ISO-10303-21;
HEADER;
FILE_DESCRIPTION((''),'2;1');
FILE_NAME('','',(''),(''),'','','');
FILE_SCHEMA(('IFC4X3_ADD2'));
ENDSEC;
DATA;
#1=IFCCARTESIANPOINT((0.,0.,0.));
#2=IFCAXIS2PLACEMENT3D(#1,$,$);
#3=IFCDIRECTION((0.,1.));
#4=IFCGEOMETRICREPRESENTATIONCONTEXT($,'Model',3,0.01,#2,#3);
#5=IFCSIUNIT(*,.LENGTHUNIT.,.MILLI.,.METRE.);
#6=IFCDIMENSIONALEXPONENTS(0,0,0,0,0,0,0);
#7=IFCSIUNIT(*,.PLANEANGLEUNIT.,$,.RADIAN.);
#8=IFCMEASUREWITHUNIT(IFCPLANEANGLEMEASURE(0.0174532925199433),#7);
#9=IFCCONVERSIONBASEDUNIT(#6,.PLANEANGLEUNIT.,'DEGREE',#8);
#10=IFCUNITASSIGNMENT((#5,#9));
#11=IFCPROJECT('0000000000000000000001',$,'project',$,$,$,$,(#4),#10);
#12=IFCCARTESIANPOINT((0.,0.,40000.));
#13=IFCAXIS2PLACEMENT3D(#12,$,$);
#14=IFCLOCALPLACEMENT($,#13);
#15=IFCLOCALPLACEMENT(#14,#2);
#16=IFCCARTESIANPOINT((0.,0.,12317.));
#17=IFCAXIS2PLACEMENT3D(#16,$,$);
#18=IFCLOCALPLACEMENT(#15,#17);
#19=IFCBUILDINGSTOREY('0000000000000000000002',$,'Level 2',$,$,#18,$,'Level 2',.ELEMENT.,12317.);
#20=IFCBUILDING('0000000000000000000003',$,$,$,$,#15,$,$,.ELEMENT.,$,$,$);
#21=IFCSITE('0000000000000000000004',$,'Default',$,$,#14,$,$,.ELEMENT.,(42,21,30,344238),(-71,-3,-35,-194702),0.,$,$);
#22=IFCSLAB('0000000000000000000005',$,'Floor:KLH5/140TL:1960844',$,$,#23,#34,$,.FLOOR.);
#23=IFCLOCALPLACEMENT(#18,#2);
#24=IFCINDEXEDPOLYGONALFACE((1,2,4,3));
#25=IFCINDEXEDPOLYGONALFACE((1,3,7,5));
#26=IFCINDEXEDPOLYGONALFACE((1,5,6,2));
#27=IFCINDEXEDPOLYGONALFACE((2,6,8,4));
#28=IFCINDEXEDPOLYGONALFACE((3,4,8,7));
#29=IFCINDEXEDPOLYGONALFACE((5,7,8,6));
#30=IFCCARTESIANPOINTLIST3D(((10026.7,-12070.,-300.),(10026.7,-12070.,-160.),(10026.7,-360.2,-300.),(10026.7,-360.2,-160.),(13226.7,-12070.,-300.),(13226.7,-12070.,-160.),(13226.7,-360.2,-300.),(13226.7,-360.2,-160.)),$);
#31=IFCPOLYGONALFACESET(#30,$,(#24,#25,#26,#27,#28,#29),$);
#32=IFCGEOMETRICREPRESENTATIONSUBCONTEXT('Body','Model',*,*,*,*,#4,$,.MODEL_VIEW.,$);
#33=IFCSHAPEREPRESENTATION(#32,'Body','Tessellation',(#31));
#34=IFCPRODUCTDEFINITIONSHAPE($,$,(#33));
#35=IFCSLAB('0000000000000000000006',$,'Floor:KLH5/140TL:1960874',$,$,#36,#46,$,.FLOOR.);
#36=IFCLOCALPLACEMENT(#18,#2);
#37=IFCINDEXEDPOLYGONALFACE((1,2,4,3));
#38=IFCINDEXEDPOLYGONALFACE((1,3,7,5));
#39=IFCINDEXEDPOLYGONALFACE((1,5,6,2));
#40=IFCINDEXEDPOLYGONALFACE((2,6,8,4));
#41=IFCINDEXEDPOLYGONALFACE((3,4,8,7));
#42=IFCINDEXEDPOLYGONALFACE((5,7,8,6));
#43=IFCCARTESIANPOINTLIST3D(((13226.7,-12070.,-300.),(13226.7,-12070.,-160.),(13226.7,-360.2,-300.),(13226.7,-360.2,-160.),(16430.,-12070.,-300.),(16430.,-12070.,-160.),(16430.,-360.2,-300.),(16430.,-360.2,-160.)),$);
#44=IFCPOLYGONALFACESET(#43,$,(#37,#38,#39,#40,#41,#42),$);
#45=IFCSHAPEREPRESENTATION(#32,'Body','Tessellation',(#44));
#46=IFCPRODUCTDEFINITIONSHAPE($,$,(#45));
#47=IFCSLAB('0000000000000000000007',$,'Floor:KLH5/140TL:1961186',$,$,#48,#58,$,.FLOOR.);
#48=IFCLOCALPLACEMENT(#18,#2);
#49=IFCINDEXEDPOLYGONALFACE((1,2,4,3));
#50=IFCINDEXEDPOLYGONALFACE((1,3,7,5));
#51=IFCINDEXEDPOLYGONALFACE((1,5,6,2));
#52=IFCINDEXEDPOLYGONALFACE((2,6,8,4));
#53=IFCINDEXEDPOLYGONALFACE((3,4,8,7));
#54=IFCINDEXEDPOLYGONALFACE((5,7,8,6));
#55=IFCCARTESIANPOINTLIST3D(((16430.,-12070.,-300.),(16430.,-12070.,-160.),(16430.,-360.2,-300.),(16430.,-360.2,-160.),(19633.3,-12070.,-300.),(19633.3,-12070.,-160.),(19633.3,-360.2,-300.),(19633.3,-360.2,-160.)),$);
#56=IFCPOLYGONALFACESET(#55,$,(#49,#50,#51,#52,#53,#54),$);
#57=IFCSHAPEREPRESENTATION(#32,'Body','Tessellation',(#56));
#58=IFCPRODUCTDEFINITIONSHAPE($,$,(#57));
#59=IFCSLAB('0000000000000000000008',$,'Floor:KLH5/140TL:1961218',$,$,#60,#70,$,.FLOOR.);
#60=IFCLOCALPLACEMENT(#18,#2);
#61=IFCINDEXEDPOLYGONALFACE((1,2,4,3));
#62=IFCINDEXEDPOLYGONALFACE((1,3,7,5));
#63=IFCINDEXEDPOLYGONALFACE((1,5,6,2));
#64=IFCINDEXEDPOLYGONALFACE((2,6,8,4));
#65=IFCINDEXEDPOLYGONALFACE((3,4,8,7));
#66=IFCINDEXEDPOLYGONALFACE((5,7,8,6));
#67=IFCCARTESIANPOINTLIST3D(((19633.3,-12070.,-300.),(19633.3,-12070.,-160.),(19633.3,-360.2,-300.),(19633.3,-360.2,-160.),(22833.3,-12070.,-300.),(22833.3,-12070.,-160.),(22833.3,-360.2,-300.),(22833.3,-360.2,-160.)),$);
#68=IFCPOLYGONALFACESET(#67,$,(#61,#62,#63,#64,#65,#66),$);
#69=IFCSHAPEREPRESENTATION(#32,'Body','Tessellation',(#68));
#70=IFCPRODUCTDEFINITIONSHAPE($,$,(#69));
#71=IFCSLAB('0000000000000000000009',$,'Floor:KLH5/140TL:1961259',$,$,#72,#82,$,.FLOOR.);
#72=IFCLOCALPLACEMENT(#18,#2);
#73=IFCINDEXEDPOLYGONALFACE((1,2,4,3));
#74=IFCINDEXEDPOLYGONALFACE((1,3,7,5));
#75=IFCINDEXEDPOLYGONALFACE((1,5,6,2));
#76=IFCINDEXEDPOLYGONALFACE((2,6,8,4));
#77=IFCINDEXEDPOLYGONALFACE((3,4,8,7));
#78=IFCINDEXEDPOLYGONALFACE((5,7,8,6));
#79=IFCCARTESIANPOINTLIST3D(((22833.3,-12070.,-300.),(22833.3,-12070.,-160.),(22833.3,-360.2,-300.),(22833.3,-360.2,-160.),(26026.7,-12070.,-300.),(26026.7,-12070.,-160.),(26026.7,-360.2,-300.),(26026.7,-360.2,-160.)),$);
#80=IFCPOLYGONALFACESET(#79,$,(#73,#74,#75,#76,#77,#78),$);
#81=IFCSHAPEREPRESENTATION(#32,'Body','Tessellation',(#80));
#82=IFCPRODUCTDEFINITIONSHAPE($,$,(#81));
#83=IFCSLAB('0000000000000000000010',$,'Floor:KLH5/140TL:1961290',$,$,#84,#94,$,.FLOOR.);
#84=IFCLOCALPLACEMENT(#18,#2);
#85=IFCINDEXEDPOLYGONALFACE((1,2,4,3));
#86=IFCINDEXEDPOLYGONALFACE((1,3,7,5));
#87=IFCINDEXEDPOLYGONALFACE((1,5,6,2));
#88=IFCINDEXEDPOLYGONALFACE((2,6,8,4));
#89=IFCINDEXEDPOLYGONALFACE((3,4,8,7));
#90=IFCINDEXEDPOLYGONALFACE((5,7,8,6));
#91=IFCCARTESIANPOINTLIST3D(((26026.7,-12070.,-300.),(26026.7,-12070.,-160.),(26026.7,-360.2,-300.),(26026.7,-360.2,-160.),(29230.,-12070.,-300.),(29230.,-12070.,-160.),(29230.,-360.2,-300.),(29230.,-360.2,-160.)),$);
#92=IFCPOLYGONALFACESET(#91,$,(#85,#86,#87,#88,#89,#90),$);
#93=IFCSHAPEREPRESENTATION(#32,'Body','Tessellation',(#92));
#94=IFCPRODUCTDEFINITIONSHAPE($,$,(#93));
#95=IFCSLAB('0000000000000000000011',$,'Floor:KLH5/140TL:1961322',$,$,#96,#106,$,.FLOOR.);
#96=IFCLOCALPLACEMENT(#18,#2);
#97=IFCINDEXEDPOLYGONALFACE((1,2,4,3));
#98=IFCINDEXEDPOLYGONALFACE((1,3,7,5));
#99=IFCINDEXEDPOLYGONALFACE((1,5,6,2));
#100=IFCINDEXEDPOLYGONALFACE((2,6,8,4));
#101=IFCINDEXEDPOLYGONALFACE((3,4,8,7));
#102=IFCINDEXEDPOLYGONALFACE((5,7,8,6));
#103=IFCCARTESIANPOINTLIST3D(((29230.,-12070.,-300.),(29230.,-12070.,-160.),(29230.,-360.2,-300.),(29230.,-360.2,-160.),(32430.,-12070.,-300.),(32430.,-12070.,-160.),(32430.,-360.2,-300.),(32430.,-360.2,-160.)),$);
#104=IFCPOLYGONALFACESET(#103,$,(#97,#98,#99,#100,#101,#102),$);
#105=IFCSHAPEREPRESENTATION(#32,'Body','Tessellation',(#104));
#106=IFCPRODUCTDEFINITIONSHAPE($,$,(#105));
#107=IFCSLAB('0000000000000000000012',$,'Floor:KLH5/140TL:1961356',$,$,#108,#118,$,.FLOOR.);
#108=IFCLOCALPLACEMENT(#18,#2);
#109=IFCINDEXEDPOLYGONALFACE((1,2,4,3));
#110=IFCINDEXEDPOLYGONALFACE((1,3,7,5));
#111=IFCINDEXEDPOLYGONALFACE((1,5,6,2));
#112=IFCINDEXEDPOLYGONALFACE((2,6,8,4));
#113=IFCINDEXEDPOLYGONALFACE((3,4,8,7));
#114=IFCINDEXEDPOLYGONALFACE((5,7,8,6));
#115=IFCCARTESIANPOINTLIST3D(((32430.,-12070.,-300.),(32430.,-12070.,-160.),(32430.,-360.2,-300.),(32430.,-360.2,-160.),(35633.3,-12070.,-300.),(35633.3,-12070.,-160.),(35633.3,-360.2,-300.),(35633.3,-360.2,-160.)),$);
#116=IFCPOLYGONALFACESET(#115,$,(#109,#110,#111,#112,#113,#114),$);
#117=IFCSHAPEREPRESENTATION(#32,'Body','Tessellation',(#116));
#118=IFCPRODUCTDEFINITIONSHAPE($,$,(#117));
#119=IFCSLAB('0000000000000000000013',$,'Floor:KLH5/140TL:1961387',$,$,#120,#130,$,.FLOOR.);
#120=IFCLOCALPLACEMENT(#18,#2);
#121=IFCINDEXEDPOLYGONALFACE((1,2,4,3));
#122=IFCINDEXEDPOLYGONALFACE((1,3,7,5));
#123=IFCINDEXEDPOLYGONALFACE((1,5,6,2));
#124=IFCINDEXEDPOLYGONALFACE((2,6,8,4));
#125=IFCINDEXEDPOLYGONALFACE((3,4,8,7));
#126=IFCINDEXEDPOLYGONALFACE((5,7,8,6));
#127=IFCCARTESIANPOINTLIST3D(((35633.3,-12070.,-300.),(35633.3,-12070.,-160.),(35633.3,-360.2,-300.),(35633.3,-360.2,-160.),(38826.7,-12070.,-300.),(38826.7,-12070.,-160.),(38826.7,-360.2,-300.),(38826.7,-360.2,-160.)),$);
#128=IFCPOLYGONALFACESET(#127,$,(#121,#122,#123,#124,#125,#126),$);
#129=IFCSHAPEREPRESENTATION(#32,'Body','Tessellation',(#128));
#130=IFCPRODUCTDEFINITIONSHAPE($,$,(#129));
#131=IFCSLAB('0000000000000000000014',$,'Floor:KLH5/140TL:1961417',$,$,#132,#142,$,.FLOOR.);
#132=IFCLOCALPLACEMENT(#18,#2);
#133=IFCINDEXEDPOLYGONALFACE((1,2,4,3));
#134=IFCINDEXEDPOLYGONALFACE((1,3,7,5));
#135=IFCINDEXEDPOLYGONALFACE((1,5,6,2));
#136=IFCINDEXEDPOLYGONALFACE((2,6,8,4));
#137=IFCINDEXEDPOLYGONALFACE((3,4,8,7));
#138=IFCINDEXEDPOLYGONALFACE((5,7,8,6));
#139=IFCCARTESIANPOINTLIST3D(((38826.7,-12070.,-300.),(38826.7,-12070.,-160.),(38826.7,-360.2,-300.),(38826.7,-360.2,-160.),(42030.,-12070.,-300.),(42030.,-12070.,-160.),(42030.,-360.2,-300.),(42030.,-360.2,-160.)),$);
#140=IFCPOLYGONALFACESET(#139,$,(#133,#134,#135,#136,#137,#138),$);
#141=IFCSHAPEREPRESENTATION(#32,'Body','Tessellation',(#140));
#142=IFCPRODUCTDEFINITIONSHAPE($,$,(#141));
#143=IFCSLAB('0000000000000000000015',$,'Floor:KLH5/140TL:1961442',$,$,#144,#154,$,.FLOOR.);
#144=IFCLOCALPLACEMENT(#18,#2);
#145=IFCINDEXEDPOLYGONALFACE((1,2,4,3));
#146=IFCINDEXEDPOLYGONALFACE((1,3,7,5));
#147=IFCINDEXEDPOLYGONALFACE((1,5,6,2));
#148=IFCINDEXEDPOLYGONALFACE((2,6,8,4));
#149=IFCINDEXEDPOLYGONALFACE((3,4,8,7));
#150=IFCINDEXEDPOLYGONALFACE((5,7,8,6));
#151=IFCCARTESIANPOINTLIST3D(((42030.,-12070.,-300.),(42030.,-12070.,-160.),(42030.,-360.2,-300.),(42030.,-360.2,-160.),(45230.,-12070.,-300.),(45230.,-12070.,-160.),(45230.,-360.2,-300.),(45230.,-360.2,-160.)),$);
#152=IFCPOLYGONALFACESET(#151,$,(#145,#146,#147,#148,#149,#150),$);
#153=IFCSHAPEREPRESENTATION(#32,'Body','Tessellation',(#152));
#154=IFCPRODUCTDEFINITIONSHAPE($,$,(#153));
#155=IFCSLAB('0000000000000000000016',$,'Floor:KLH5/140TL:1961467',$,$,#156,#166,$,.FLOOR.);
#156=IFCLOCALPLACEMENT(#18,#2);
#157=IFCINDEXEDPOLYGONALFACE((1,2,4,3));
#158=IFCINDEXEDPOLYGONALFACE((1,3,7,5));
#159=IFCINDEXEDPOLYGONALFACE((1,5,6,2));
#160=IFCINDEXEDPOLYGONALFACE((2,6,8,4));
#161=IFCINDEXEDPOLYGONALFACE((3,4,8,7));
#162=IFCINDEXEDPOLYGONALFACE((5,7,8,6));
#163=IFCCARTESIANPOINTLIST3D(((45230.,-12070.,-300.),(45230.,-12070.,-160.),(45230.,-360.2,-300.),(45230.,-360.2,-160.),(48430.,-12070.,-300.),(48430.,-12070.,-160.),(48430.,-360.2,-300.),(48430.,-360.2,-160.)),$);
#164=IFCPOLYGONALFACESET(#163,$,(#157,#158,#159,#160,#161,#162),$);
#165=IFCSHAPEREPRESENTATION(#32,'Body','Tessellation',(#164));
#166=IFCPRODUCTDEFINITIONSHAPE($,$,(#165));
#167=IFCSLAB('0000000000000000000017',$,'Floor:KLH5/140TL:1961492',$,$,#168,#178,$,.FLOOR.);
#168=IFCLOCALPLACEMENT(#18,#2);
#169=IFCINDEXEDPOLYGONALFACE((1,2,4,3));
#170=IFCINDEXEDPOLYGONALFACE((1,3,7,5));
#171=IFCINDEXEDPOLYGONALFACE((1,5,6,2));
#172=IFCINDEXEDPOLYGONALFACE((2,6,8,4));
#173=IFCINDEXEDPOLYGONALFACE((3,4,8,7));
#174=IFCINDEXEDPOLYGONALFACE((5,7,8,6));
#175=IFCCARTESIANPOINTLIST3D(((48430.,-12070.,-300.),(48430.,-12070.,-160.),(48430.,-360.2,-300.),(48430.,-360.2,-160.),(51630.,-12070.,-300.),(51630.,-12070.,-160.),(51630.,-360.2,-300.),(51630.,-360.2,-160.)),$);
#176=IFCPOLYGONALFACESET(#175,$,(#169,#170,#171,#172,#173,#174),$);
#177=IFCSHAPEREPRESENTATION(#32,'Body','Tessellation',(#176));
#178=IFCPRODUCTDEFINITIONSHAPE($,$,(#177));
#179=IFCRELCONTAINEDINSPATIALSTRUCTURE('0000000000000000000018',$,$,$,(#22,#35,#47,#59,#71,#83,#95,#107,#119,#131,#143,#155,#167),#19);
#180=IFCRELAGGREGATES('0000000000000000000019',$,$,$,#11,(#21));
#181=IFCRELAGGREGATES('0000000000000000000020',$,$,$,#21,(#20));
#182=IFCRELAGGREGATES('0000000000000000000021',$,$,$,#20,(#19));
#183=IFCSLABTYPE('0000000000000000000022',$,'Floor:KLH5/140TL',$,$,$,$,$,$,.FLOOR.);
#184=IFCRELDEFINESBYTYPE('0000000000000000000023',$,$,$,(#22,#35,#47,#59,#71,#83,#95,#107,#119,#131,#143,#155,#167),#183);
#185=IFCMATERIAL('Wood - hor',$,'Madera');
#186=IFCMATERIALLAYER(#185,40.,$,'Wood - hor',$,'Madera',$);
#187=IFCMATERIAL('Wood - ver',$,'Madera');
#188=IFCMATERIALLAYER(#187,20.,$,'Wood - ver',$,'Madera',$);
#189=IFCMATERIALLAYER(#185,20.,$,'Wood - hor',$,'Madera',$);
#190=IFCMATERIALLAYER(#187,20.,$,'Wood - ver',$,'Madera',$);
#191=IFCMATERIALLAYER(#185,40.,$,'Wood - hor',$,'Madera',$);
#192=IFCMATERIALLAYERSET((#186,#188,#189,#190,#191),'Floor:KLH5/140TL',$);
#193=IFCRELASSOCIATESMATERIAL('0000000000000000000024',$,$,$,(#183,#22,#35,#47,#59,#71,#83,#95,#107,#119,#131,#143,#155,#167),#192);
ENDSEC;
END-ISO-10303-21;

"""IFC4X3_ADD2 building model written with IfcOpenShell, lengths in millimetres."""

from ifc_helpers import new_model, entity, si_unit, converted_unit, direction, frame, frame_2d, origin, origin_2d_with_axis, place, context, subcontext, project, spatial, rectangle, extrude, material, layer, layer_set, layer_usage, type_object, element, save


model = new_model("IFC4X3_ADD2")

# Units and contexts
model_context = context("Model", 3, precision=0.01, world=origin(), true_north=direction((0.0, 1.0)))
body_context = subcontext(model_context, "Body", "Model", "MODEL_VIEW")
ifc_project = project(units=[si_unit("LENGTHUNIT", "METRE", prefix="MILLI"), converted_unit("PLANEANGLEUNIT", "DEGREE", entity("IfcPlaneAngleMeasure", 0.0174532925199433), si_unit("PLANEANGLEUNIT", "RADIAN"), dimensions=[0, 0, 0, 0, 0, 0, 0])], contexts=[model_context])

# Site, building, storey
site_placement = place(None, frame((0.0, 0.0, 40000.0)))
site = spatial("IfcSite", under=ifc_project, at=site_placement, Name="Default", CompositionType="ELEMENT", RefLatitude=(42, 21, 30, 344238), RefLongitude=(-71, -3, -35, -194702), RefElevation=0.0)
building_placement = place(site_placement, origin())
building = spatial("IfcBuilding", under=site, at=building_placement, CompositionType="ELEMENT")
storey_placement = place(building_placement, frame((0.0, 0.0, 12317.0)))
storey = spatial("IfcBuildingStorey", under=building, at=storey_placement, Name="Level 2", LongName="Level 2", CompositionType="ELEMENT", Elevation=12317.0)

# Slabs
ifc_material_1 = material(Name="Wood - hor", Category="Madera")
ifc_layer_1 = layer(ifc_material_1, 40.0, Name="Wood - hor", Category="Madera")
ifc_material_2 = material(Name="Wood - ver", Category="Madera")
ifc_layer_2 = layer(ifc_material_2, 20.0, Name="Wood - ver", Category="Madera")
ifc_layer_3 = layer(ifc_material_1, 20.0, Name="Wood - hor", Category="Madera")
ifc_layer_4 = layer(ifc_material_2, 20.0, Name="Wood - ver", Category="Madera")
ifc_layer_5 = layer(ifc_material_1, 40.0, Name="Wood - hor", Category="Madera")
ifc_layer_set_1 = layer_set([ifc_layer_1, ifc_layer_2, ifc_layer_3, ifc_layer_4, ifc_layer_5], Name="Floor:KLH5/140TL")
slab_type_1 = type_object("IfcSlabType", Name="Floor:KLH5/140TL", PredefinedType="FLOOR", material=ifc_layer_set_1)
ifc_layer_usage_1 = layer_usage(ifc_layer_set_1, "AXIS3", "POSITIVE", 0.0)
slab_1_placement = place(storey_placement, origin())
element("IfcSlab", 1, at=slab_1_placement, inside=storey, type_object=slab_type_1, material=ifc_layer_usage_1, Name="Floor:KLH5/140TL:1960844", PredefinedType="FLOOR", context=body_context, shape_type="SweptSolid", body=[
    extrude(rectangle(XDim=11709.8, YDim=3200.0, at=frame_2d((0.0, 0.0), x_axis=(1.0, 0.0))), frame((11626.7, -6215.1, -160.0), z_axis=(0.0, 0.0, -1.0), x_axis=(0.0, 1.0, 0.0)), (0.0, 0.0, 1.0), 140.0),
])
ifc_layer_usage_2 = layer_usage(ifc_layer_set_1, "AXIS3", "POSITIVE", 0.0)
slab_2_placement = place(storey_placement, origin())
element("IfcSlab", 2, at=slab_2_placement, inside=storey, type_object=slab_type_1, material=ifc_layer_usage_2, Name="Floor:KLH5/140TL:1960874", PredefinedType="FLOOR", context=body_context, shape_type="SweptSolid", body=[
    extrude(rectangle(XDim=11709.8, YDim=3203.3, at=origin_2d_with_axis()), frame((14828.4, -6215.1, -160.0), z_axis=(0.0, 0.0, -1.0), x_axis=(0.0, 1.0, 0.0)), (0.0, 0.0, 1.0), 140.0),
])
ifc_layer_usage_3 = layer_usage(ifc_layer_set_1, "AXIS3", "POSITIVE", 0.0)
slab_3_placement = place(storey_placement, origin())
element("IfcSlab", 3, at=slab_3_placement, inside=storey, type_object=slab_type_1, material=ifc_layer_usage_3, Name="Floor:KLH5/140TL:1961186", PredefinedType="FLOOR", context=body_context, shape_type="SweptSolid", body=[
    extrude(rectangle(XDim=11709.8, YDim=3203.3, at=origin_2d_with_axis()), frame((18031.7, -6215.1, -160.0), z_axis=(0.0, 0.0, -1.0), x_axis=(0.0, 1.0, 0.0)), (0.0, 0.0, 1.0), 140.0),
])
ifc_layer_usage_4 = layer_usage(ifc_layer_set_1, "AXIS3", "POSITIVE", 0.0)
slab_4_placement = place(storey_placement, origin())
element("IfcSlab", 4, at=slab_4_placement, inside=storey, type_object=slab_type_1, material=ifc_layer_usage_4, Name="Floor:KLH5/140TL:1961218", PredefinedType="FLOOR", context=body_context, shape_type="SweptSolid", body=[
    extrude(rectangle(XDim=11709.8, YDim=3200.0, at=origin_2d_with_axis()), frame((21233.3, -6215.1, -160.0), z_axis=(0.0, 0.0, -1.0), x_axis=(0.0, 1.0, 0.0)), (0.0, 0.0, 1.0), 140.0),
])
ifc_layer_usage_5 = layer_usage(ifc_layer_set_1, "AXIS3", "POSITIVE", 0.0)
slab_5_placement = place(storey_placement, origin())
element("IfcSlab", 5, at=slab_5_placement, inside=storey, type_object=slab_type_1, material=ifc_layer_usage_5, Name="Floor:KLH5/140TL:1961259", PredefinedType="FLOOR", context=body_context, shape_type="SweptSolid", body=[
    extrude(rectangle(XDim=11709.8, YDim=3193.4, at=origin_2d_with_axis()), frame((24430.0, -6215.1, -160.0), z_axis=(0.0, 0.0, -1.0), x_axis=(0.0, 1.0, 0.0)), (0.0, 0.0, 1.0), 140.0),
])
ifc_layer_usage_6 = layer_usage(ifc_layer_set_1, "AXIS3", "POSITIVE", 0.0)
slab_6_placement = place(storey_placement, origin())
element("IfcSlab", 6, at=slab_6_placement, inside=storey, type_object=slab_type_1, material=ifc_layer_usage_6, Name="Floor:KLH5/140TL:1961290", PredefinedType="FLOOR", context=body_context, shape_type="SweptSolid", body=[
    extrude(rectangle(XDim=11709.8, YDim=3203.3, at=frame_2d((0.0, 0.0), x_axis=(1.0, 0.0))), frame((27628.3, -6215.1, -160.0), z_axis=(0.0, 0.0, -1.0), x_axis=(0.0, 1.0, 0.0)), (0.0, 0.0, 1.0), 140.0),
])
ifc_layer_usage_7 = layer_usage(ifc_layer_set_1, "AXIS3", "POSITIVE", 0.0)
slab_7_placement = place(storey_placement, origin())
element("IfcSlab", 7, at=slab_7_placement, inside=storey, type_object=slab_type_1, material=ifc_layer_usage_7, Name="Floor:KLH5/140TL:1961322", PredefinedType="FLOOR", context=body_context, shape_type="SweptSolid", body=[
    extrude(rectangle(XDim=11709.8, YDim=3200.0, at=origin_2d_with_axis()), frame((30830.0, -6215.1, -160.0), z_axis=(0.0, 0.0, -1.0), x_axis=(0.0, 1.0, 0.0)), (0.0, 0.0, 1.0), 140.0),
])
ifc_layer_usage_8 = layer_usage(ifc_layer_set_1, "AXIS3", "POSITIVE", 0.0)
slab_8_placement = place(storey_placement, origin())
element("IfcSlab", 8, at=slab_8_placement, inside=storey, type_object=slab_type_1, material=ifc_layer_usage_8, Name="Floor:KLH5/140TL:1961356", PredefinedType="FLOOR", context=body_context, shape_type="SweptSolid", body=[
    extrude(rectangle(XDim=11709.8, YDim=3203.3, at=frame_2d((0.0, 0.0), x_axis=(1.0, 0.0))), frame((34031.7, -6215.1, -160.0), z_axis=(0.0, 0.0, -1.0), x_axis=(0.0, 1.0, 0.0)), (0.0, 0.0, 1.0), 140.0),
])
ifc_layer_usage_9 = layer_usage(ifc_layer_set_1, "AXIS3", "POSITIVE", 0.0)
slab_9_placement = place(storey_placement, origin())
element("IfcSlab", 9, at=slab_9_placement, inside=storey, type_object=slab_type_1, material=ifc_layer_usage_9, Name="Floor:KLH5/140TL:1961387", PredefinedType="FLOOR", context=body_context, shape_type="SweptSolid", body=[
    extrude(rectangle(XDim=11709.8, YDim=3193.4, at=origin_2d_with_axis()), frame((37230.0, -6215.1, -160.0), z_axis=(0.0, 0.0, -1.0), x_axis=(0.0, 1.0, 0.0)), (0.0, 0.0, 1.0), 140.0),
])
ifc_layer_usage_10 = layer_usage(ifc_layer_set_1, "AXIS3", "POSITIVE", 0.0)
slab_10_placement = place(storey_placement, origin())
element("IfcSlab", 10, at=slab_10_placement, inside=storey, type_object=slab_type_1, material=ifc_layer_usage_10, Name="Floor:KLH5/140TL:1961417", PredefinedType="FLOOR", context=body_context, shape_type="SweptSolid", body=[
    extrude(rectangle(XDim=11709.8, YDim=3203.3, at=frame_2d((0.0, 0.0), x_axis=(1.0, 0.0))), frame((40428.3, -6215.1, -160.0), z_axis=(0.0, 0.0, -1.0), x_axis=(0.0, 1.0, 0.0)), (0.0, 0.0, 1.0), 140.0),
])
ifc_layer_usage_11 = layer_usage(ifc_layer_set_1, "AXIS3", "POSITIVE", 0.0)
slab_11_placement = place(storey_placement, origin())
element("IfcSlab", 11, at=slab_11_placement, inside=storey, type_object=slab_type_1, material=ifc_layer_usage_11, Name="Floor:KLH5/140TL:1961442", PredefinedType="FLOOR", context=body_context, shape_type="SweptSolid", body=[
    extrude(rectangle(XDim=11709.8, YDim=3200.0, at=origin_2d_with_axis()), frame((43630.0, -6215.1, -160.0), z_axis=(0.0, 0.0, -1.0), x_axis=(0.0, 1.0, 0.0)), (0.0, 0.0, 1.0), 140.0),
])
ifc_layer_usage_12 = layer_usage(ifc_layer_set_1, "AXIS3", "POSITIVE", 0.0)
slab_12_placement = place(storey_placement, origin())
element("IfcSlab", 12, at=slab_12_placement, inside=storey, type_object=slab_type_1, material=ifc_layer_usage_12, Name="Floor:KLH5/140TL:1961467", PredefinedType="FLOOR", context=body_context, shape_type="SweptSolid", body=[
    extrude(rectangle(XDim=11709.8, YDim=3200.0, at=origin_2d_with_axis()), frame((46830.0, -6215.1, -160.0), z_axis=(0.0, 0.0, -1.0), x_axis=(0.0, 1.0, 0.0)), (0.0, 0.0, 1.0), 140.0),
])
ifc_layer_usage_13 = layer_usage(ifc_layer_set_1, "AXIS3", "POSITIVE", 0.0)
slab_13_placement = place(storey_placement, origin())
element("IfcSlab", 13, at=slab_13_placement, inside=storey, type_object=slab_type_1, material=ifc_layer_usage_13, Name="Floor:KLH5/140TL:1961492", PredefinedType="FLOOR", context=body_context, shape_type="SweptSolid", body=[
    extrude(rectangle(XDim=11709.8, YDim=3200.0, at=origin_2d_with_axis()), frame((50030.0, -6215.1, -160.0), z_axis=(0.0, 0.0, -1.0), x_axis=(0.0, 1.0, 0.0)), (0.0, 0.0, 1.0), 140.0),
])

save(model, "model.ifc")
